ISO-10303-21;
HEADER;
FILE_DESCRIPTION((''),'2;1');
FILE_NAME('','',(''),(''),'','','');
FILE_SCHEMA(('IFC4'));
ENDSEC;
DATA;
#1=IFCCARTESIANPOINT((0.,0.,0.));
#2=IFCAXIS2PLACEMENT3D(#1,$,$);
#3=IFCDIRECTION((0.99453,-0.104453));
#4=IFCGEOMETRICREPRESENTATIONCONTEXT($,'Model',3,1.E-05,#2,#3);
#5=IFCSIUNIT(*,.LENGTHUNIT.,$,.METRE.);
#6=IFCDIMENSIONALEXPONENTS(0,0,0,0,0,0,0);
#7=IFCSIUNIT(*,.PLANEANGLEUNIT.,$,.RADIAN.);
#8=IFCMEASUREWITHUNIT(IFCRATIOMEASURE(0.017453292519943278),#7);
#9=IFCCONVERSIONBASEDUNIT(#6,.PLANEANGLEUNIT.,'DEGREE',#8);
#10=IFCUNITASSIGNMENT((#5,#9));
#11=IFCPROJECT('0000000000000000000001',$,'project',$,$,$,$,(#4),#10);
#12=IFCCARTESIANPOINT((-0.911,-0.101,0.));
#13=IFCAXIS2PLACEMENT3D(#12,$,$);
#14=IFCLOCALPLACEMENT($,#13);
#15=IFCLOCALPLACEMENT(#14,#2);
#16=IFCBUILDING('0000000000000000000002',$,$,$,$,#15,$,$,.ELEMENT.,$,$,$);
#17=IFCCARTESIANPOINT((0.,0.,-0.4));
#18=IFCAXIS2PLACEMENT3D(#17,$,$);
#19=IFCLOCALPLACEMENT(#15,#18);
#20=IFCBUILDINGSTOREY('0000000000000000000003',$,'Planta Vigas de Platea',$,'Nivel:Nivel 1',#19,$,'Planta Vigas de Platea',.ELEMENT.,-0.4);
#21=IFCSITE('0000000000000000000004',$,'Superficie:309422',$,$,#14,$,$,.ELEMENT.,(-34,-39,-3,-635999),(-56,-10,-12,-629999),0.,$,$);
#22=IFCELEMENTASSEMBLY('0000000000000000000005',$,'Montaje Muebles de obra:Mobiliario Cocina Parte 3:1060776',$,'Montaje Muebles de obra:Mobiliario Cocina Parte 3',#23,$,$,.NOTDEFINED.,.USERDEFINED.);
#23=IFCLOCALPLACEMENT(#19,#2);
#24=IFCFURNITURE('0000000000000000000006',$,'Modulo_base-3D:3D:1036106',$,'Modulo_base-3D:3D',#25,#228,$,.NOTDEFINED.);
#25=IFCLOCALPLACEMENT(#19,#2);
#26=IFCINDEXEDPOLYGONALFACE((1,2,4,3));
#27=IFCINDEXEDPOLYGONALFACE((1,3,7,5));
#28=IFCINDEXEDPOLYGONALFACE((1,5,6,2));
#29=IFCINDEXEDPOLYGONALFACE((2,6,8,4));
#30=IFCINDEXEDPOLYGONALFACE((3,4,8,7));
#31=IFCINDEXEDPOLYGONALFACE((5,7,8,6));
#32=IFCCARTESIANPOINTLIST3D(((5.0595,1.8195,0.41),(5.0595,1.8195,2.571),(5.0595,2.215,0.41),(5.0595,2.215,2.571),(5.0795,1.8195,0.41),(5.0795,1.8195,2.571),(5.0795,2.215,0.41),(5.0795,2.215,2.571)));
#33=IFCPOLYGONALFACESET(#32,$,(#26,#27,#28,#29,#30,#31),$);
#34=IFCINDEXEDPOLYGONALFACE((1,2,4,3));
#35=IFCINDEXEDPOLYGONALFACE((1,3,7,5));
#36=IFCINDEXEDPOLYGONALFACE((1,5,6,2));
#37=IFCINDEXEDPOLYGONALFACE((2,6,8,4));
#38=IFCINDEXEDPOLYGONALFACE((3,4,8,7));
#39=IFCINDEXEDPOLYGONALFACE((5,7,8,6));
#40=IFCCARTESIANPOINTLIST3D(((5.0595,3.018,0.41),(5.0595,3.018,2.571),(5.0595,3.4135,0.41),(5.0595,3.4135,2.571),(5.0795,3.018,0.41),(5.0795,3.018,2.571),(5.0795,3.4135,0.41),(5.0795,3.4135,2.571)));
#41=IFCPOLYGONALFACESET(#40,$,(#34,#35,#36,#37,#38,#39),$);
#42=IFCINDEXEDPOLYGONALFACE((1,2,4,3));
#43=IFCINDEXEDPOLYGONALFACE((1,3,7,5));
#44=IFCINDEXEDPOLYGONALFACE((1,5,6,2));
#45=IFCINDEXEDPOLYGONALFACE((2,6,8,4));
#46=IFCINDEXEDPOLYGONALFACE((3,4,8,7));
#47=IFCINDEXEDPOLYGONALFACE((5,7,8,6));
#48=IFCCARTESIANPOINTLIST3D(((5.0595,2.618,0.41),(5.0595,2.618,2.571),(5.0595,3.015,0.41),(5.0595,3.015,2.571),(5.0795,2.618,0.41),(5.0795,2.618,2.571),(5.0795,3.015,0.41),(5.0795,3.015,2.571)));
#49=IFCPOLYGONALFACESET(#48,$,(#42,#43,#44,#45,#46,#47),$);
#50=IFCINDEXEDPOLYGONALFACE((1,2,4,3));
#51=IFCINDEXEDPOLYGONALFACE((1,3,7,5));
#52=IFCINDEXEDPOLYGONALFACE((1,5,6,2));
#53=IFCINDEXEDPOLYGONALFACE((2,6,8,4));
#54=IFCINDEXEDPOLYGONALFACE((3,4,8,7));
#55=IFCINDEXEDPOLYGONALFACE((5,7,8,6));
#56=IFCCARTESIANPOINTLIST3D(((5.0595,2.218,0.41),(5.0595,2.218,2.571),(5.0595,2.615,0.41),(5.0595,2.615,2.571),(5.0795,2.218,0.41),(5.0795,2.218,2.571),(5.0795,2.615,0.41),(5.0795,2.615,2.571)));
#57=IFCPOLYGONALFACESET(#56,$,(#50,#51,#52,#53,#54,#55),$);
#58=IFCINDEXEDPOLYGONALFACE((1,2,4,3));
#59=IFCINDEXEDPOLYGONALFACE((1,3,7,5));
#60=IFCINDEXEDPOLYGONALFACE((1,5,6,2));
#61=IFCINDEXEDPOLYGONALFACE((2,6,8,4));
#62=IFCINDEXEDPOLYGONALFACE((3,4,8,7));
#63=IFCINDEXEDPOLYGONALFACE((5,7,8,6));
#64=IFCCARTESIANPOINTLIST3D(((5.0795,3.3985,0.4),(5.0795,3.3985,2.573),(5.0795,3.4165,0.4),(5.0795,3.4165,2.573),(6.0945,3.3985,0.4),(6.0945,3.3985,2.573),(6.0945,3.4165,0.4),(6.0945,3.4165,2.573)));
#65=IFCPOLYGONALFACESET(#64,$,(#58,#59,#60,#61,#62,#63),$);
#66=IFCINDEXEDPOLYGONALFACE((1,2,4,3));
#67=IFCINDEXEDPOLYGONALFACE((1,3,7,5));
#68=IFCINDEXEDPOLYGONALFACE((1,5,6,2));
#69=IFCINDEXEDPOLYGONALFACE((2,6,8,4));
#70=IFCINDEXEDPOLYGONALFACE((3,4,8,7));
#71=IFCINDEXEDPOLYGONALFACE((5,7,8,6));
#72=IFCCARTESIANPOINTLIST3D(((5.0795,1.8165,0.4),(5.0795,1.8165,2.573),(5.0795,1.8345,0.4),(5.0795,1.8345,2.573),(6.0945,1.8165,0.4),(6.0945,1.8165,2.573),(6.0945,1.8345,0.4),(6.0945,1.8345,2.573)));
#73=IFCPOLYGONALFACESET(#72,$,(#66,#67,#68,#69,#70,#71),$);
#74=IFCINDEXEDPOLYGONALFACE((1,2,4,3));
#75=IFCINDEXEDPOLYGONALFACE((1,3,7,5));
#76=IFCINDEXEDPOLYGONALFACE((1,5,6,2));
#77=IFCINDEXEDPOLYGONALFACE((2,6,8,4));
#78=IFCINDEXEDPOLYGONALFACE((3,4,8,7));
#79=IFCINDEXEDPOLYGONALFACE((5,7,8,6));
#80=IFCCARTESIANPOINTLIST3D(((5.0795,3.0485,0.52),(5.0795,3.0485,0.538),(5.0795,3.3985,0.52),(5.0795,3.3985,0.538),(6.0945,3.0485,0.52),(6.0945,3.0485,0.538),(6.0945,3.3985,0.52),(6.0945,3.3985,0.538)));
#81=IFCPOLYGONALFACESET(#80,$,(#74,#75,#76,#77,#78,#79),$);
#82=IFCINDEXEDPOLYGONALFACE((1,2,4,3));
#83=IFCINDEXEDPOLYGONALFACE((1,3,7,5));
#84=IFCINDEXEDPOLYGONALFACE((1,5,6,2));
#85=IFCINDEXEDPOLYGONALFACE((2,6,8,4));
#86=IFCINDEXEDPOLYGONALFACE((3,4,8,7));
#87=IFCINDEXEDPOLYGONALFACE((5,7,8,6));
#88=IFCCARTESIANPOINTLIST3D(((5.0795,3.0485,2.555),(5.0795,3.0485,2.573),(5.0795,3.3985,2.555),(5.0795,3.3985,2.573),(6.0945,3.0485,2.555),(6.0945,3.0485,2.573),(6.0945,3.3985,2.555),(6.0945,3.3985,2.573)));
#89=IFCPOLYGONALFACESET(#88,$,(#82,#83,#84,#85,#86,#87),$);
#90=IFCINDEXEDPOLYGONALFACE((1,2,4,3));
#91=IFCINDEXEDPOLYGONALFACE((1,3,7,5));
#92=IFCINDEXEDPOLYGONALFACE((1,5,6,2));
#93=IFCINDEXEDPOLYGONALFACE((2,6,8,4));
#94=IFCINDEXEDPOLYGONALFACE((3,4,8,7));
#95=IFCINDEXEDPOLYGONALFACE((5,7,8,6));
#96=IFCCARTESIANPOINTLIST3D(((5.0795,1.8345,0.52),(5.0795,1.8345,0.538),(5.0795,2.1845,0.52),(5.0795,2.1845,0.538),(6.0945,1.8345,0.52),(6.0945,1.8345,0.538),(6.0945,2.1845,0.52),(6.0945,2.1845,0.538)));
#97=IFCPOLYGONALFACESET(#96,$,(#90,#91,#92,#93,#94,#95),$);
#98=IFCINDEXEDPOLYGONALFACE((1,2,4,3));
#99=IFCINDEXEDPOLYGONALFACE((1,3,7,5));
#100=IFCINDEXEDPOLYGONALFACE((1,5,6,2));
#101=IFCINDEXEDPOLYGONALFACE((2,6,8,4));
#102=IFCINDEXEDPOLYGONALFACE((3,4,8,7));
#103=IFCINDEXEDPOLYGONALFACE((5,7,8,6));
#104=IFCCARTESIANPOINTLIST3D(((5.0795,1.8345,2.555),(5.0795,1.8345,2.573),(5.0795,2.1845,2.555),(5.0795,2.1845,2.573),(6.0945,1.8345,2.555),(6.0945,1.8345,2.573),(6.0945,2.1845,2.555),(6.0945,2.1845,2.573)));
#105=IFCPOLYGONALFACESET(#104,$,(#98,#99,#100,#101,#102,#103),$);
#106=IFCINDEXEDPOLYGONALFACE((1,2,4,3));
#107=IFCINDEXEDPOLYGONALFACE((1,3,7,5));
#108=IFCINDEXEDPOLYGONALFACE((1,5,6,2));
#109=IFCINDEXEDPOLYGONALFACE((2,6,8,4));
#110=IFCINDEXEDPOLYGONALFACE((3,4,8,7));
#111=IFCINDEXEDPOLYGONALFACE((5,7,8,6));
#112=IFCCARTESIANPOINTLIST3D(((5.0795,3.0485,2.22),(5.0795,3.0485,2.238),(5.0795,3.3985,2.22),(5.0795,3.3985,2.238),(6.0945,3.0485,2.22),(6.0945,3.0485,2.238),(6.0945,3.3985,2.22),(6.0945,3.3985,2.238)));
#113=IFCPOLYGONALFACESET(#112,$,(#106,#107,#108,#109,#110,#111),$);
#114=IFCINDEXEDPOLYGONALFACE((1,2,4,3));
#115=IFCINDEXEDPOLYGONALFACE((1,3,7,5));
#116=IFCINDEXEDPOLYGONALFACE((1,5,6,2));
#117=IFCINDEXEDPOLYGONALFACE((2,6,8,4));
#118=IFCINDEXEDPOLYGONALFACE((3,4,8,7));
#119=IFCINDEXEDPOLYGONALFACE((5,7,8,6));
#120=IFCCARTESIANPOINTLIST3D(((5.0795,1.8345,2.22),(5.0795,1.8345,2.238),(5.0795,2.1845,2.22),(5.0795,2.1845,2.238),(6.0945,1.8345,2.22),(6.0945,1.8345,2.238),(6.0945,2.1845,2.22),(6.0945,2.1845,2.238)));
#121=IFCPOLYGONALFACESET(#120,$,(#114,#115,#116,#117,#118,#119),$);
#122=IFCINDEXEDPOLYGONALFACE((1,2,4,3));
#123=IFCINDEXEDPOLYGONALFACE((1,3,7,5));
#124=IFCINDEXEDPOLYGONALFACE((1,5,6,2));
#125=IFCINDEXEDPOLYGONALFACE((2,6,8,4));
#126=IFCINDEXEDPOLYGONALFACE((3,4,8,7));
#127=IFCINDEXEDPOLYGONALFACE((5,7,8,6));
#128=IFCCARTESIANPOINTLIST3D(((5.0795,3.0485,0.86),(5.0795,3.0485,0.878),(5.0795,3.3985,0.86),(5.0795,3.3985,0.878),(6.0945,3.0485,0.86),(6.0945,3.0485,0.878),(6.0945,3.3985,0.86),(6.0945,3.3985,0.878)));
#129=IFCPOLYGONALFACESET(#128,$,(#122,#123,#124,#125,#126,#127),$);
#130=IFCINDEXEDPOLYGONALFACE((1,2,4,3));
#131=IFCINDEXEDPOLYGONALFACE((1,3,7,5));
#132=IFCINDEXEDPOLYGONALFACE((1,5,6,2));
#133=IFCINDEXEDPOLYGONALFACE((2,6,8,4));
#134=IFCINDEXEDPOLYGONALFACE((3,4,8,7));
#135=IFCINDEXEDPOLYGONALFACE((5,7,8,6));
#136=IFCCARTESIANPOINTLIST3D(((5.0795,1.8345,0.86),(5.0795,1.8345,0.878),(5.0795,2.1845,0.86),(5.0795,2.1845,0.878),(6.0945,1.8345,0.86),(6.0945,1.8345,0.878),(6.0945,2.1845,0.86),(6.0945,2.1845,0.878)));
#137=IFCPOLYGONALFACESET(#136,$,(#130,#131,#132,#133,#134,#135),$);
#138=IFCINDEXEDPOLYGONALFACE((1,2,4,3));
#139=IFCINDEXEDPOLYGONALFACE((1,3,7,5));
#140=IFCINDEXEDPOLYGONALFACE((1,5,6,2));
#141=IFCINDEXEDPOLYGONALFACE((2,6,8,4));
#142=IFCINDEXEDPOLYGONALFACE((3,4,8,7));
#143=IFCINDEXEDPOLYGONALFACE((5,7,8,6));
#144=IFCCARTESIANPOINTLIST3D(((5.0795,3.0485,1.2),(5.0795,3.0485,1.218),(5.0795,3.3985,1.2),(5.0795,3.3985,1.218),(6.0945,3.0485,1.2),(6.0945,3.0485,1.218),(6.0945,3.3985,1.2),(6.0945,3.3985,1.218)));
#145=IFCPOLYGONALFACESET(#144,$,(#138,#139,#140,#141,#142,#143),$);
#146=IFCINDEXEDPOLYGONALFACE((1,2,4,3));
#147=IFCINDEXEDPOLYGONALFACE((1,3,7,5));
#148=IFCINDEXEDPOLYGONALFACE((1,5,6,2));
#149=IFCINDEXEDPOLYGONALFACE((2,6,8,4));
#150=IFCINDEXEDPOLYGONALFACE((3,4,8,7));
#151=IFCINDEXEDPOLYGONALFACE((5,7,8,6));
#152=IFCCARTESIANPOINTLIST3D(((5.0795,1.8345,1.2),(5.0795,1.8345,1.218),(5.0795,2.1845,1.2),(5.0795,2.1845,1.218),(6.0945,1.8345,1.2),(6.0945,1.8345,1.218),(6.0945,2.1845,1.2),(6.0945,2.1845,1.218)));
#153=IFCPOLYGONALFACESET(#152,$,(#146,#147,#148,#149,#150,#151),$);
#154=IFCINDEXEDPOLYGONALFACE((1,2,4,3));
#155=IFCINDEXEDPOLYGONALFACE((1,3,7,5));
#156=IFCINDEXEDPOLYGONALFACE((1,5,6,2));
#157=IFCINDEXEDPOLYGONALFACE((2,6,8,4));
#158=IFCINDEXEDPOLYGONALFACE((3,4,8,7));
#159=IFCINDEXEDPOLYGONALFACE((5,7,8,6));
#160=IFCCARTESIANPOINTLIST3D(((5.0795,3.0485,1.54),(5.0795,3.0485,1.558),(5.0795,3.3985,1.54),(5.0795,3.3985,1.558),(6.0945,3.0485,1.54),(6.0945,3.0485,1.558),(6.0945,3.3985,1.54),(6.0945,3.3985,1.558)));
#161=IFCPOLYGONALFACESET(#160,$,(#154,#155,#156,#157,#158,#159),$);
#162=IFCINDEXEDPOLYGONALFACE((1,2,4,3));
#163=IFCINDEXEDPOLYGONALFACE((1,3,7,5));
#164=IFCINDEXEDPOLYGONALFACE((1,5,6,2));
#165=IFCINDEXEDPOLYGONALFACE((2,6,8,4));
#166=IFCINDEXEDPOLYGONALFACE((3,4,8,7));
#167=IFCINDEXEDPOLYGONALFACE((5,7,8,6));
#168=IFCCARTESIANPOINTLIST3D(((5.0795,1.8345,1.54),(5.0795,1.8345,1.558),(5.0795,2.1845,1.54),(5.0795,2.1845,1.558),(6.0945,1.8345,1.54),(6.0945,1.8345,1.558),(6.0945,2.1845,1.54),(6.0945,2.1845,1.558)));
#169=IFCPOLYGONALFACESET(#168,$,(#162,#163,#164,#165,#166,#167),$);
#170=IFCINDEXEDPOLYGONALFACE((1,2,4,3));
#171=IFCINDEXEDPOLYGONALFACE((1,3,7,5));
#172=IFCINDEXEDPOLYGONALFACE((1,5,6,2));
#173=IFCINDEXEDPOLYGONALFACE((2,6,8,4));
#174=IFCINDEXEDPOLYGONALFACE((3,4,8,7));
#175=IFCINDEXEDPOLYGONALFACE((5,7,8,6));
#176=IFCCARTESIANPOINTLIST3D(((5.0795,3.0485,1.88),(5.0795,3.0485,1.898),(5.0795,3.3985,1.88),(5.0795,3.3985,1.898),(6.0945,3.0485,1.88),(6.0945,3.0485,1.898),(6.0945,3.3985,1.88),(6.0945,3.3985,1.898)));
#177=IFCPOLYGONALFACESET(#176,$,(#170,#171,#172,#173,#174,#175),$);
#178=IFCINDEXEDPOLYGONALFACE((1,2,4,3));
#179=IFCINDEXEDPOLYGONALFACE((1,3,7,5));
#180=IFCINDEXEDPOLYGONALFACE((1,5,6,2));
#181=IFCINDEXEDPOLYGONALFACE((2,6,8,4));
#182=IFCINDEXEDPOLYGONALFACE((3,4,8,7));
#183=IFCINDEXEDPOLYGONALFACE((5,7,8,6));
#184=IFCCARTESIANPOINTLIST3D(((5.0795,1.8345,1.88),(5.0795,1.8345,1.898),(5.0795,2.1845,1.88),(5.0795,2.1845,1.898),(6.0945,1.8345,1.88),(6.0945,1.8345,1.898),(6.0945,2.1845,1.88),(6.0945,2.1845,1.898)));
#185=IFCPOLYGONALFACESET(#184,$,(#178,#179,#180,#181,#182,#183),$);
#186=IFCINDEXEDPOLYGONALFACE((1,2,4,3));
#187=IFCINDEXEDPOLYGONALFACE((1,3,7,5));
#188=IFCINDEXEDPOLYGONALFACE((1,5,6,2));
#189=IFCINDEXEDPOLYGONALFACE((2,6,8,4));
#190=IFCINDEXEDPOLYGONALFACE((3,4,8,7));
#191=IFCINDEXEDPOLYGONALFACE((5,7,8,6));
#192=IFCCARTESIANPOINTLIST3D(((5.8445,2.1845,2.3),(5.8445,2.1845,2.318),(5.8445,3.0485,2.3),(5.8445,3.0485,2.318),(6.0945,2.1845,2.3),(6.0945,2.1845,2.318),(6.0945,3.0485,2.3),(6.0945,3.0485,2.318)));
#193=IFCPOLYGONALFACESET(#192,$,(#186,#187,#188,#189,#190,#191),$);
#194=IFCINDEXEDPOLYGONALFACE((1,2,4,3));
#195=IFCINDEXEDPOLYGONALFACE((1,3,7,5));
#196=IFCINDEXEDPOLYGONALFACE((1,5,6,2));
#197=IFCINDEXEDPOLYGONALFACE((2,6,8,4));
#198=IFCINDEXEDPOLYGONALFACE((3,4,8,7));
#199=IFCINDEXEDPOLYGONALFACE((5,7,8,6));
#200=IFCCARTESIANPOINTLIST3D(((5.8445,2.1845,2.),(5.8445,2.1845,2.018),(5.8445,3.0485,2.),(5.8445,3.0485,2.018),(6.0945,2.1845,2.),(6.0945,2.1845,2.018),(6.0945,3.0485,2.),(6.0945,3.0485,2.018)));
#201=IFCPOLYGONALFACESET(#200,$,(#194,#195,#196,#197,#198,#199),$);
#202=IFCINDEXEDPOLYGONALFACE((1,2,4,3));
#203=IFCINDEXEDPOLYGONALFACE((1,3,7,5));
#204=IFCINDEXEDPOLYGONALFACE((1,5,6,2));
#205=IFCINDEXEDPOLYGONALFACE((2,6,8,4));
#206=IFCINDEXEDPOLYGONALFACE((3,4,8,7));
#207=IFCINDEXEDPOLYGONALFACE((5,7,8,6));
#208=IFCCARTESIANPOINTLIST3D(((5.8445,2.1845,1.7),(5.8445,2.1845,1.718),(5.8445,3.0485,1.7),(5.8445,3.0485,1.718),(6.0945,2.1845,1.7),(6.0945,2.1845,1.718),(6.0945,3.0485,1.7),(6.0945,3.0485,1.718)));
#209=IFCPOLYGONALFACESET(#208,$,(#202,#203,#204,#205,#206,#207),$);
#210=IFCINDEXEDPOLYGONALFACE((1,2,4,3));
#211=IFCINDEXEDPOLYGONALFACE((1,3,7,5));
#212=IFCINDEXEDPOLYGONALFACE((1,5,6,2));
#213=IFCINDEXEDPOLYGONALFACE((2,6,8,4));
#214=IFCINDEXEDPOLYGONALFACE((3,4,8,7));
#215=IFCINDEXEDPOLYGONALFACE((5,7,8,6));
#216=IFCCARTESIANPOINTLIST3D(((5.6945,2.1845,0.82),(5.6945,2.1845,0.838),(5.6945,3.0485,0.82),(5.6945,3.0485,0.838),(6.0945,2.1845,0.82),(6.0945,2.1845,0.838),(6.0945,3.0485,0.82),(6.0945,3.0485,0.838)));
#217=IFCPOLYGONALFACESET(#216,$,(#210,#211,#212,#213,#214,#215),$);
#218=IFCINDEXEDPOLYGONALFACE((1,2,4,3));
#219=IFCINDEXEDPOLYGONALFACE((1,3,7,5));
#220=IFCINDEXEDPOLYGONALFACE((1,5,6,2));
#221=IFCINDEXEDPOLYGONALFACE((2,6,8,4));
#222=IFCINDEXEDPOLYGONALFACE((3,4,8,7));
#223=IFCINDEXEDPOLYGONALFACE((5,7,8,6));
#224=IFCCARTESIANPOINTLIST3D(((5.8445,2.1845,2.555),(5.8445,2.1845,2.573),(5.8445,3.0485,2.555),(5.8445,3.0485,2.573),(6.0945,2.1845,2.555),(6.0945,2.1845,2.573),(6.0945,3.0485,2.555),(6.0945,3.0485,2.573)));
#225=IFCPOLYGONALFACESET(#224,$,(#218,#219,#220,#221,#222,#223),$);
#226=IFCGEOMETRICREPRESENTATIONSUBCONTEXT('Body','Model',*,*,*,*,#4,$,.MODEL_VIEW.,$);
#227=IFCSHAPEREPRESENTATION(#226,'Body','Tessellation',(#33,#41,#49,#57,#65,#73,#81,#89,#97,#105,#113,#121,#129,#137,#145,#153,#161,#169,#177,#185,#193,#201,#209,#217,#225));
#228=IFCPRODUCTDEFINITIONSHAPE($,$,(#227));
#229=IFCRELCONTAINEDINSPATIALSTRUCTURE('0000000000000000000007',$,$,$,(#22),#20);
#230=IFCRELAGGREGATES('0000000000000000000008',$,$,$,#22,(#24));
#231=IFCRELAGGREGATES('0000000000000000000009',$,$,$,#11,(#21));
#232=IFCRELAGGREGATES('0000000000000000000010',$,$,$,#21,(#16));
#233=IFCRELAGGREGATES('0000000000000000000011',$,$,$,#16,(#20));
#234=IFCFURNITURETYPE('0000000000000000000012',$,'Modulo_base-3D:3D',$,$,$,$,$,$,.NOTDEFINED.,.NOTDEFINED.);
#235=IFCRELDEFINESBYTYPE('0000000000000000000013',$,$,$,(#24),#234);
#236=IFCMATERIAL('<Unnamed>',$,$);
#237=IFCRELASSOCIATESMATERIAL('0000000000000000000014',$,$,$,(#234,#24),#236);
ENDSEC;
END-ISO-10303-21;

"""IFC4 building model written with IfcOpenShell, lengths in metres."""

from ifc_helpers import new_model, entity, si_unit, converted_unit, direction, frame, frame_2d, origin, origin_2d_with_axis, place, context, subcontext, project, spatial, rectangle, extrude, source, transform, mapped, material, type_object, type_shapes, element, aggregate, save


model = new_model("IFC4")

# Units and contexts
model_context = context("Model", 3, precision=1e-05, world=origin(), true_north=direction((0.99453, -0.104453)))
body_context = subcontext(model_context, "Body", "Model", "MODEL_VIEW")
ifc_project = project(units=[si_unit("LENGTHUNIT", "METRE"), converted_unit("PLANEANGLEUNIT", "DEGREE", entity("IfcRatioMeasure", 0.017453292519943278), si_unit("PLANEANGLEUNIT", "RADIAN"), dimensions=[0, 0, 0, 0, 0, 0, 0])], contexts=[model_context])

# Site, building, storey
site_placement = place(None, frame((-0.911, -0.101, 0.0)))
site = spatial("IfcSite", under=ifc_project, at=site_placement, Name="Superficie:309422", CompositionType="ELEMENT", RefLatitude=(-34, -39, -3, -635999), RefLongitude=(-56, -10, -12, -629999), RefElevation=0.0)
building_placement = place(site_placement, origin())
building = spatial("IfcBuilding", under=site, at=building_placement, CompositionType="ELEMENT")
storey_placement = place(building_placement, frame((0.0, 0.0, -0.4)))
storey = spatial("IfcBuildingStorey", under=building, at=storey_placement, Name="Planta Vigas de Platea", ObjectType="Nivel:Nivel 1", LongName="Planta Vigas de Platea", CompositionType="ELEMENT", Elevation=-0.4)

# Element assembly
ifc_material_1 = material(Name="<Unnamed>")
assembly_1_placement = place(storey_placement, origin())
assembly_1 = element("IfcElementAssembly", 1, at=assembly_1_placement, inside=storey, Name="Montaje Muebles de obra:Mobiliario Cocina Parte 3:1060776", ObjectType="Montaje Muebles de obra:Mobiliario Cocina Parte 3", AssemblyPlace="NOTDEFINED", PredefinedType="USERDEFINED")

# Furniture
furniture_type_1 = type_object("IfcFurnitureType", Name="Modulo_base-3D:3D", AssemblyPlace="NOTDEFINED", PredefinedType="NOTDEFINED", material=ifc_material_1)
shared_shape_1 = source(origin(), body_context, "Body", "SweptSolid", [
    extrude(rectangle(XDim=0.02, YDim=0.3955, at=frame_2d((0.0, 0.0), x_axis=(1.0, 0.0))), frame((0.01, 0.2008, 0.01)), (0.0, 0.0, 1.0), 2.161),
    extrude(rectangle(XDim=0.02, YDim=0.3955, at=frame_2d((0.0, 0.0), x_axis=(1.0, 0.0))), frame((0.01, 1.3993, 0.01)), (0.0, 0.0, 1.0), 2.161),
    extrude(rectangle(XDim=0.02, YDim=0.397, at=origin_2d_with_axis()), frame((0.01, 1.0, 0.01)), (0.0, 0.0, 1.0), 2.161),
    extrude(rectangle(XDim=0.02, YDim=0.397, at=frame_2d((0.0, 0.0), x_axis=(1.0, 0.0))), frame((0.01, 0.6, 0.01)), (0.0, 0.0, 1.0), 2.161),
    extrude(rectangle(XDim=0.018, YDim=1.015, at=frame_2d((-0.003, -0.1558), x_axis=(1.0, 0.0))), frame((0.3717, 1.594, 0.0), z_axis=(0.0, 0.0, 1.0), x_axis=(0.0, 1.0, 0.0)), (0.0, 0.0, 1.0), 2.173),
    extrude(rectangle(XDim=0.018, YDim=1.015, at=frame_2d((-0.003, 0.0112), x_axis=(1.0, 0.0))), frame((0.5163, 0.006, 0.0), z_axis=(0.0, 0.0, 1.0), x_axis=(0.0, -1.0, 0.0)), (0.0, 0.0, 1.0), 2.173),
    extrude(rectangle(XDim=1.015, YDim=0.35, at=frame_2d((0.0, 0.0), x_axis=(1.0, 0.0))), frame((0.5275, 1.407, 0.12), z_axis=(0.0, 0.0, 1.0), x_axis=(-1.0, 0.0, 0.0)), (0.0, 0.0, 1.0), 0.018),
    extrude(rectangle(XDim=1.015, YDim=0.35, at=frame_2d((0.0515, -0.035), x_axis=(1.0, 0.0))), frame((0.579, 1.372, 2.155), z_axis=(0.0, 0.0, 1.0), x_axis=(-1.0, 0.0, 0.0)), (0.0, 0.0, 1.0), 0.018),
    extrude(rectangle(XDim=0.35, YDim=1.015, at=frame_2d((0.0, 0.0), x_axis=(1.0, 0.0))), frame((0.5275, 0.193, 0.12), z_axis=(0.0, 0.0, 1.0), x_axis=(0.0, 1.0, 0.0)), (0.0, 0.0, 1.0), 0.018),
    extrude(rectangle(XDim=0.35, YDim=1.015, at=frame_2d((-0.035, 0.0515), x_axis=(1.0, 0.0))), frame((0.579, 0.228, 2.155), z_axis=(0.0, 0.0, 1.0), x_axis=(0.0, 1.0, 0.0)), (0.0, 0.0, 1.0), 0.018),
    extrude(rectangle(XDim=1.015, YDim=0.35, at=frame_2d((0.0, 0.0), x_axis=(1.0, 0.0))), frame((0.5275, 1.407, 1.82), z_axis=(0.0, 0.0, 1.0), x_axis=(-1.0, 0.0, 0.0)), (0.0, 0.0, 1.0), 0.018),
    extrude(rectangle(XDim=0.35, YDim=1.015, at=frame_2d((0.0, 0.0), x_axis=(1.0, 0.0))), frame((0.5275, 0.193, 1.82), z_axis=(0.0, 0.0, 1.0), x_axis=(0.0, 1.0, 0.0)), (0.0, 0.0, 1.0), 0.018),
    extrude(rectangle(XDim=1.015, YDim=0.35, at=frame_2d((0.0, 0.0), x_axis=(1.0, 0.0))), frame((0.5275, 1.407, 0.46), z_axis=(0.0, 0.0, 1.0), x_axis=(-1.0, 0.0, 0.0)), (0.0, 0.0, 1.0), 0.018),
    extrude(rectangle(XDim=0.35, YDim=1.015, at=frame_2d((0.0, 0.0), x_axis=(1.0, 0.0))), frame((0.5275, 0.193, 0.46), z_axis=(0.0, 0.0, 1.0), x_axis=(0.0, 1.0, 0.0)), (0.0, 0.0, 1.0), 0.018),
    extrude(rectangle(XDim=1.015, YDim=0.35, at=frame_2d((0.0, 0.0), x_axis=(1.0, 0.0))), frame((0.5275, 1.407, 0.8), z_axis=(0.0, 0.0, 1.0), x_axis=(-1.0, 0.0, 0.0)), (0.0, 0.0, 1.0), 0.018),
    extrude(rectangle(XDim=0.35, YDim=1.015, at=frame_2d((0.0, 0.0), x_axis=(1.0, 0.0))), frame((0.5275, 0.193, 0.8), z_axis=(0.0, 0.0, 1.0), x_axis=(0.0, 1.0, 0.0)), (0.0, 0.0, 1.0), 0.018),
    extrude(rectangle(XDim=1.015, YDim=0.35, at=frame_2d((0.0, 0.0), x_axis=(1.0, 0.0))), frame((0.5275, 1.407, 1.14), z_axis=(0.0, 0.0, 1.0), x_axis=(-1.0, 0.0, 0.0)), (0.0, 0.0, 1.0), 0.018),
    extrude(rectangle(XDim=0.35, YDim=1.015, at=frame_2d((0.0, 0.0), x_axis=(1.0, 0.0))), frame((0.5275, 0.193, 1.14), z_axis=(0.0, 0.0, 1.0), x_axis=(0.0, 1.0, 0.0)), (0.0, 0.0, 1.0), 0.018),
    extrude(rectangle(XDim=1.015, YDim=0.35, at=frame_2d((0.0, 0.0), x_axis=(1.0, 0.0))), frame((0.5275, 1.407, 1.48), z_axis=(0.0, 0.0, 1.0), x_axis=(-1.0, 0.0, 0.0)), (0.0, 0.0, 1.0), 0.018),
    extrude(rectangle(XDim=0.35, YDim=1.015, at=frame_2d((0.0, 0.0), x_axis=(1.0, 0.0))), frame((0.5275, 0.193, 1.48), z_axis=(0.0, 0.0, 1.0), x_axis=(0.0, 1.0, 0.0)), (0.0, 0.0, 1.0), 0.018),
    extrude(rectangle(XDim=0.864, YDim=0.25, at=frame_2d((0.0, 0.0), x_axis=(1.0, 0.0))), frame((0.91, 0.8, 1.9), z_axis=(0.0, 0.0, 1.0), x_axis=(0.0, 1.0, 0.0)), (0.0, 0.0, 1.0), 0.018),
    extrude(rectangle(XDim=0.864, YDim=0.25, at=frame_2d((0.0, 0.0), x_axis=(1.0, 0.0))), frame((0.91, 0.8, 1.6), z_axis=(0.0, 0.0, 1.0), x_axis=(0.0, 1.0, 0.0)), (0.0, 0.0, 1.0), 0.018),
    extrude(rectangle(XDim=0.864, YDim=0.25, at=frame_2d((0.0, 0.0), x_axis=(1.0, 0.0))), frame((0.91, 0.8, 1.3), z_axis=(0.0, 0.0, 1.0), x_axis=(0.0, 1.0, 0.0)), (0.0, 0.0, 1.0), 0.018),
    extrude(rectangle(XDim=0.864, YDim=0.4, at=frame_2d((0.0, 0.0), x_axis=(1.0, 0.0))), frame((0.835, 0.8, 0.42), z_axis=(0.0, 0.0, 1.0), x_axis=(0.0, 1.0, 0.0)), (0.0, 0.0, 1.0), 0.018),
    extrude(rectangle(XDim=0.864, YDim=0.25, at=frame_2d((0.0, 0.0), x_axis=(1.0, 0.0))), frame((0.91, 0.8, 2.155), z_axis=(0.0, 0.0, 1.0), x_axis=(0.0, 1.0, 0.0)), (0.0, 0.0, 1.0), 0.018),
])
type_shapes(furniture_type_1, [shared_shape_1])
furniture_1_placement = place(assembly_1_placement, frame((5.0595, 1.8165, 0.4)))
furniture_1 = element("IfcFurniture", 2, at=furniture_1_placement, type_object=furniture_type_1, material=ifc_material_1, Name="Modulo_base-3D:3D:1036106", ObjectType="Modulo_base-3D:3D", PredefinedType="NOTDEFINED", context=body_context, shape_type="MappedRepresentation", body=[
    mapped(shared_shape_1, transform((0.0, 0.0, 0.0), scale=1.0)),
])
aggregate(assembly_1, [furniture_1])

save(model, "model.ifc")
